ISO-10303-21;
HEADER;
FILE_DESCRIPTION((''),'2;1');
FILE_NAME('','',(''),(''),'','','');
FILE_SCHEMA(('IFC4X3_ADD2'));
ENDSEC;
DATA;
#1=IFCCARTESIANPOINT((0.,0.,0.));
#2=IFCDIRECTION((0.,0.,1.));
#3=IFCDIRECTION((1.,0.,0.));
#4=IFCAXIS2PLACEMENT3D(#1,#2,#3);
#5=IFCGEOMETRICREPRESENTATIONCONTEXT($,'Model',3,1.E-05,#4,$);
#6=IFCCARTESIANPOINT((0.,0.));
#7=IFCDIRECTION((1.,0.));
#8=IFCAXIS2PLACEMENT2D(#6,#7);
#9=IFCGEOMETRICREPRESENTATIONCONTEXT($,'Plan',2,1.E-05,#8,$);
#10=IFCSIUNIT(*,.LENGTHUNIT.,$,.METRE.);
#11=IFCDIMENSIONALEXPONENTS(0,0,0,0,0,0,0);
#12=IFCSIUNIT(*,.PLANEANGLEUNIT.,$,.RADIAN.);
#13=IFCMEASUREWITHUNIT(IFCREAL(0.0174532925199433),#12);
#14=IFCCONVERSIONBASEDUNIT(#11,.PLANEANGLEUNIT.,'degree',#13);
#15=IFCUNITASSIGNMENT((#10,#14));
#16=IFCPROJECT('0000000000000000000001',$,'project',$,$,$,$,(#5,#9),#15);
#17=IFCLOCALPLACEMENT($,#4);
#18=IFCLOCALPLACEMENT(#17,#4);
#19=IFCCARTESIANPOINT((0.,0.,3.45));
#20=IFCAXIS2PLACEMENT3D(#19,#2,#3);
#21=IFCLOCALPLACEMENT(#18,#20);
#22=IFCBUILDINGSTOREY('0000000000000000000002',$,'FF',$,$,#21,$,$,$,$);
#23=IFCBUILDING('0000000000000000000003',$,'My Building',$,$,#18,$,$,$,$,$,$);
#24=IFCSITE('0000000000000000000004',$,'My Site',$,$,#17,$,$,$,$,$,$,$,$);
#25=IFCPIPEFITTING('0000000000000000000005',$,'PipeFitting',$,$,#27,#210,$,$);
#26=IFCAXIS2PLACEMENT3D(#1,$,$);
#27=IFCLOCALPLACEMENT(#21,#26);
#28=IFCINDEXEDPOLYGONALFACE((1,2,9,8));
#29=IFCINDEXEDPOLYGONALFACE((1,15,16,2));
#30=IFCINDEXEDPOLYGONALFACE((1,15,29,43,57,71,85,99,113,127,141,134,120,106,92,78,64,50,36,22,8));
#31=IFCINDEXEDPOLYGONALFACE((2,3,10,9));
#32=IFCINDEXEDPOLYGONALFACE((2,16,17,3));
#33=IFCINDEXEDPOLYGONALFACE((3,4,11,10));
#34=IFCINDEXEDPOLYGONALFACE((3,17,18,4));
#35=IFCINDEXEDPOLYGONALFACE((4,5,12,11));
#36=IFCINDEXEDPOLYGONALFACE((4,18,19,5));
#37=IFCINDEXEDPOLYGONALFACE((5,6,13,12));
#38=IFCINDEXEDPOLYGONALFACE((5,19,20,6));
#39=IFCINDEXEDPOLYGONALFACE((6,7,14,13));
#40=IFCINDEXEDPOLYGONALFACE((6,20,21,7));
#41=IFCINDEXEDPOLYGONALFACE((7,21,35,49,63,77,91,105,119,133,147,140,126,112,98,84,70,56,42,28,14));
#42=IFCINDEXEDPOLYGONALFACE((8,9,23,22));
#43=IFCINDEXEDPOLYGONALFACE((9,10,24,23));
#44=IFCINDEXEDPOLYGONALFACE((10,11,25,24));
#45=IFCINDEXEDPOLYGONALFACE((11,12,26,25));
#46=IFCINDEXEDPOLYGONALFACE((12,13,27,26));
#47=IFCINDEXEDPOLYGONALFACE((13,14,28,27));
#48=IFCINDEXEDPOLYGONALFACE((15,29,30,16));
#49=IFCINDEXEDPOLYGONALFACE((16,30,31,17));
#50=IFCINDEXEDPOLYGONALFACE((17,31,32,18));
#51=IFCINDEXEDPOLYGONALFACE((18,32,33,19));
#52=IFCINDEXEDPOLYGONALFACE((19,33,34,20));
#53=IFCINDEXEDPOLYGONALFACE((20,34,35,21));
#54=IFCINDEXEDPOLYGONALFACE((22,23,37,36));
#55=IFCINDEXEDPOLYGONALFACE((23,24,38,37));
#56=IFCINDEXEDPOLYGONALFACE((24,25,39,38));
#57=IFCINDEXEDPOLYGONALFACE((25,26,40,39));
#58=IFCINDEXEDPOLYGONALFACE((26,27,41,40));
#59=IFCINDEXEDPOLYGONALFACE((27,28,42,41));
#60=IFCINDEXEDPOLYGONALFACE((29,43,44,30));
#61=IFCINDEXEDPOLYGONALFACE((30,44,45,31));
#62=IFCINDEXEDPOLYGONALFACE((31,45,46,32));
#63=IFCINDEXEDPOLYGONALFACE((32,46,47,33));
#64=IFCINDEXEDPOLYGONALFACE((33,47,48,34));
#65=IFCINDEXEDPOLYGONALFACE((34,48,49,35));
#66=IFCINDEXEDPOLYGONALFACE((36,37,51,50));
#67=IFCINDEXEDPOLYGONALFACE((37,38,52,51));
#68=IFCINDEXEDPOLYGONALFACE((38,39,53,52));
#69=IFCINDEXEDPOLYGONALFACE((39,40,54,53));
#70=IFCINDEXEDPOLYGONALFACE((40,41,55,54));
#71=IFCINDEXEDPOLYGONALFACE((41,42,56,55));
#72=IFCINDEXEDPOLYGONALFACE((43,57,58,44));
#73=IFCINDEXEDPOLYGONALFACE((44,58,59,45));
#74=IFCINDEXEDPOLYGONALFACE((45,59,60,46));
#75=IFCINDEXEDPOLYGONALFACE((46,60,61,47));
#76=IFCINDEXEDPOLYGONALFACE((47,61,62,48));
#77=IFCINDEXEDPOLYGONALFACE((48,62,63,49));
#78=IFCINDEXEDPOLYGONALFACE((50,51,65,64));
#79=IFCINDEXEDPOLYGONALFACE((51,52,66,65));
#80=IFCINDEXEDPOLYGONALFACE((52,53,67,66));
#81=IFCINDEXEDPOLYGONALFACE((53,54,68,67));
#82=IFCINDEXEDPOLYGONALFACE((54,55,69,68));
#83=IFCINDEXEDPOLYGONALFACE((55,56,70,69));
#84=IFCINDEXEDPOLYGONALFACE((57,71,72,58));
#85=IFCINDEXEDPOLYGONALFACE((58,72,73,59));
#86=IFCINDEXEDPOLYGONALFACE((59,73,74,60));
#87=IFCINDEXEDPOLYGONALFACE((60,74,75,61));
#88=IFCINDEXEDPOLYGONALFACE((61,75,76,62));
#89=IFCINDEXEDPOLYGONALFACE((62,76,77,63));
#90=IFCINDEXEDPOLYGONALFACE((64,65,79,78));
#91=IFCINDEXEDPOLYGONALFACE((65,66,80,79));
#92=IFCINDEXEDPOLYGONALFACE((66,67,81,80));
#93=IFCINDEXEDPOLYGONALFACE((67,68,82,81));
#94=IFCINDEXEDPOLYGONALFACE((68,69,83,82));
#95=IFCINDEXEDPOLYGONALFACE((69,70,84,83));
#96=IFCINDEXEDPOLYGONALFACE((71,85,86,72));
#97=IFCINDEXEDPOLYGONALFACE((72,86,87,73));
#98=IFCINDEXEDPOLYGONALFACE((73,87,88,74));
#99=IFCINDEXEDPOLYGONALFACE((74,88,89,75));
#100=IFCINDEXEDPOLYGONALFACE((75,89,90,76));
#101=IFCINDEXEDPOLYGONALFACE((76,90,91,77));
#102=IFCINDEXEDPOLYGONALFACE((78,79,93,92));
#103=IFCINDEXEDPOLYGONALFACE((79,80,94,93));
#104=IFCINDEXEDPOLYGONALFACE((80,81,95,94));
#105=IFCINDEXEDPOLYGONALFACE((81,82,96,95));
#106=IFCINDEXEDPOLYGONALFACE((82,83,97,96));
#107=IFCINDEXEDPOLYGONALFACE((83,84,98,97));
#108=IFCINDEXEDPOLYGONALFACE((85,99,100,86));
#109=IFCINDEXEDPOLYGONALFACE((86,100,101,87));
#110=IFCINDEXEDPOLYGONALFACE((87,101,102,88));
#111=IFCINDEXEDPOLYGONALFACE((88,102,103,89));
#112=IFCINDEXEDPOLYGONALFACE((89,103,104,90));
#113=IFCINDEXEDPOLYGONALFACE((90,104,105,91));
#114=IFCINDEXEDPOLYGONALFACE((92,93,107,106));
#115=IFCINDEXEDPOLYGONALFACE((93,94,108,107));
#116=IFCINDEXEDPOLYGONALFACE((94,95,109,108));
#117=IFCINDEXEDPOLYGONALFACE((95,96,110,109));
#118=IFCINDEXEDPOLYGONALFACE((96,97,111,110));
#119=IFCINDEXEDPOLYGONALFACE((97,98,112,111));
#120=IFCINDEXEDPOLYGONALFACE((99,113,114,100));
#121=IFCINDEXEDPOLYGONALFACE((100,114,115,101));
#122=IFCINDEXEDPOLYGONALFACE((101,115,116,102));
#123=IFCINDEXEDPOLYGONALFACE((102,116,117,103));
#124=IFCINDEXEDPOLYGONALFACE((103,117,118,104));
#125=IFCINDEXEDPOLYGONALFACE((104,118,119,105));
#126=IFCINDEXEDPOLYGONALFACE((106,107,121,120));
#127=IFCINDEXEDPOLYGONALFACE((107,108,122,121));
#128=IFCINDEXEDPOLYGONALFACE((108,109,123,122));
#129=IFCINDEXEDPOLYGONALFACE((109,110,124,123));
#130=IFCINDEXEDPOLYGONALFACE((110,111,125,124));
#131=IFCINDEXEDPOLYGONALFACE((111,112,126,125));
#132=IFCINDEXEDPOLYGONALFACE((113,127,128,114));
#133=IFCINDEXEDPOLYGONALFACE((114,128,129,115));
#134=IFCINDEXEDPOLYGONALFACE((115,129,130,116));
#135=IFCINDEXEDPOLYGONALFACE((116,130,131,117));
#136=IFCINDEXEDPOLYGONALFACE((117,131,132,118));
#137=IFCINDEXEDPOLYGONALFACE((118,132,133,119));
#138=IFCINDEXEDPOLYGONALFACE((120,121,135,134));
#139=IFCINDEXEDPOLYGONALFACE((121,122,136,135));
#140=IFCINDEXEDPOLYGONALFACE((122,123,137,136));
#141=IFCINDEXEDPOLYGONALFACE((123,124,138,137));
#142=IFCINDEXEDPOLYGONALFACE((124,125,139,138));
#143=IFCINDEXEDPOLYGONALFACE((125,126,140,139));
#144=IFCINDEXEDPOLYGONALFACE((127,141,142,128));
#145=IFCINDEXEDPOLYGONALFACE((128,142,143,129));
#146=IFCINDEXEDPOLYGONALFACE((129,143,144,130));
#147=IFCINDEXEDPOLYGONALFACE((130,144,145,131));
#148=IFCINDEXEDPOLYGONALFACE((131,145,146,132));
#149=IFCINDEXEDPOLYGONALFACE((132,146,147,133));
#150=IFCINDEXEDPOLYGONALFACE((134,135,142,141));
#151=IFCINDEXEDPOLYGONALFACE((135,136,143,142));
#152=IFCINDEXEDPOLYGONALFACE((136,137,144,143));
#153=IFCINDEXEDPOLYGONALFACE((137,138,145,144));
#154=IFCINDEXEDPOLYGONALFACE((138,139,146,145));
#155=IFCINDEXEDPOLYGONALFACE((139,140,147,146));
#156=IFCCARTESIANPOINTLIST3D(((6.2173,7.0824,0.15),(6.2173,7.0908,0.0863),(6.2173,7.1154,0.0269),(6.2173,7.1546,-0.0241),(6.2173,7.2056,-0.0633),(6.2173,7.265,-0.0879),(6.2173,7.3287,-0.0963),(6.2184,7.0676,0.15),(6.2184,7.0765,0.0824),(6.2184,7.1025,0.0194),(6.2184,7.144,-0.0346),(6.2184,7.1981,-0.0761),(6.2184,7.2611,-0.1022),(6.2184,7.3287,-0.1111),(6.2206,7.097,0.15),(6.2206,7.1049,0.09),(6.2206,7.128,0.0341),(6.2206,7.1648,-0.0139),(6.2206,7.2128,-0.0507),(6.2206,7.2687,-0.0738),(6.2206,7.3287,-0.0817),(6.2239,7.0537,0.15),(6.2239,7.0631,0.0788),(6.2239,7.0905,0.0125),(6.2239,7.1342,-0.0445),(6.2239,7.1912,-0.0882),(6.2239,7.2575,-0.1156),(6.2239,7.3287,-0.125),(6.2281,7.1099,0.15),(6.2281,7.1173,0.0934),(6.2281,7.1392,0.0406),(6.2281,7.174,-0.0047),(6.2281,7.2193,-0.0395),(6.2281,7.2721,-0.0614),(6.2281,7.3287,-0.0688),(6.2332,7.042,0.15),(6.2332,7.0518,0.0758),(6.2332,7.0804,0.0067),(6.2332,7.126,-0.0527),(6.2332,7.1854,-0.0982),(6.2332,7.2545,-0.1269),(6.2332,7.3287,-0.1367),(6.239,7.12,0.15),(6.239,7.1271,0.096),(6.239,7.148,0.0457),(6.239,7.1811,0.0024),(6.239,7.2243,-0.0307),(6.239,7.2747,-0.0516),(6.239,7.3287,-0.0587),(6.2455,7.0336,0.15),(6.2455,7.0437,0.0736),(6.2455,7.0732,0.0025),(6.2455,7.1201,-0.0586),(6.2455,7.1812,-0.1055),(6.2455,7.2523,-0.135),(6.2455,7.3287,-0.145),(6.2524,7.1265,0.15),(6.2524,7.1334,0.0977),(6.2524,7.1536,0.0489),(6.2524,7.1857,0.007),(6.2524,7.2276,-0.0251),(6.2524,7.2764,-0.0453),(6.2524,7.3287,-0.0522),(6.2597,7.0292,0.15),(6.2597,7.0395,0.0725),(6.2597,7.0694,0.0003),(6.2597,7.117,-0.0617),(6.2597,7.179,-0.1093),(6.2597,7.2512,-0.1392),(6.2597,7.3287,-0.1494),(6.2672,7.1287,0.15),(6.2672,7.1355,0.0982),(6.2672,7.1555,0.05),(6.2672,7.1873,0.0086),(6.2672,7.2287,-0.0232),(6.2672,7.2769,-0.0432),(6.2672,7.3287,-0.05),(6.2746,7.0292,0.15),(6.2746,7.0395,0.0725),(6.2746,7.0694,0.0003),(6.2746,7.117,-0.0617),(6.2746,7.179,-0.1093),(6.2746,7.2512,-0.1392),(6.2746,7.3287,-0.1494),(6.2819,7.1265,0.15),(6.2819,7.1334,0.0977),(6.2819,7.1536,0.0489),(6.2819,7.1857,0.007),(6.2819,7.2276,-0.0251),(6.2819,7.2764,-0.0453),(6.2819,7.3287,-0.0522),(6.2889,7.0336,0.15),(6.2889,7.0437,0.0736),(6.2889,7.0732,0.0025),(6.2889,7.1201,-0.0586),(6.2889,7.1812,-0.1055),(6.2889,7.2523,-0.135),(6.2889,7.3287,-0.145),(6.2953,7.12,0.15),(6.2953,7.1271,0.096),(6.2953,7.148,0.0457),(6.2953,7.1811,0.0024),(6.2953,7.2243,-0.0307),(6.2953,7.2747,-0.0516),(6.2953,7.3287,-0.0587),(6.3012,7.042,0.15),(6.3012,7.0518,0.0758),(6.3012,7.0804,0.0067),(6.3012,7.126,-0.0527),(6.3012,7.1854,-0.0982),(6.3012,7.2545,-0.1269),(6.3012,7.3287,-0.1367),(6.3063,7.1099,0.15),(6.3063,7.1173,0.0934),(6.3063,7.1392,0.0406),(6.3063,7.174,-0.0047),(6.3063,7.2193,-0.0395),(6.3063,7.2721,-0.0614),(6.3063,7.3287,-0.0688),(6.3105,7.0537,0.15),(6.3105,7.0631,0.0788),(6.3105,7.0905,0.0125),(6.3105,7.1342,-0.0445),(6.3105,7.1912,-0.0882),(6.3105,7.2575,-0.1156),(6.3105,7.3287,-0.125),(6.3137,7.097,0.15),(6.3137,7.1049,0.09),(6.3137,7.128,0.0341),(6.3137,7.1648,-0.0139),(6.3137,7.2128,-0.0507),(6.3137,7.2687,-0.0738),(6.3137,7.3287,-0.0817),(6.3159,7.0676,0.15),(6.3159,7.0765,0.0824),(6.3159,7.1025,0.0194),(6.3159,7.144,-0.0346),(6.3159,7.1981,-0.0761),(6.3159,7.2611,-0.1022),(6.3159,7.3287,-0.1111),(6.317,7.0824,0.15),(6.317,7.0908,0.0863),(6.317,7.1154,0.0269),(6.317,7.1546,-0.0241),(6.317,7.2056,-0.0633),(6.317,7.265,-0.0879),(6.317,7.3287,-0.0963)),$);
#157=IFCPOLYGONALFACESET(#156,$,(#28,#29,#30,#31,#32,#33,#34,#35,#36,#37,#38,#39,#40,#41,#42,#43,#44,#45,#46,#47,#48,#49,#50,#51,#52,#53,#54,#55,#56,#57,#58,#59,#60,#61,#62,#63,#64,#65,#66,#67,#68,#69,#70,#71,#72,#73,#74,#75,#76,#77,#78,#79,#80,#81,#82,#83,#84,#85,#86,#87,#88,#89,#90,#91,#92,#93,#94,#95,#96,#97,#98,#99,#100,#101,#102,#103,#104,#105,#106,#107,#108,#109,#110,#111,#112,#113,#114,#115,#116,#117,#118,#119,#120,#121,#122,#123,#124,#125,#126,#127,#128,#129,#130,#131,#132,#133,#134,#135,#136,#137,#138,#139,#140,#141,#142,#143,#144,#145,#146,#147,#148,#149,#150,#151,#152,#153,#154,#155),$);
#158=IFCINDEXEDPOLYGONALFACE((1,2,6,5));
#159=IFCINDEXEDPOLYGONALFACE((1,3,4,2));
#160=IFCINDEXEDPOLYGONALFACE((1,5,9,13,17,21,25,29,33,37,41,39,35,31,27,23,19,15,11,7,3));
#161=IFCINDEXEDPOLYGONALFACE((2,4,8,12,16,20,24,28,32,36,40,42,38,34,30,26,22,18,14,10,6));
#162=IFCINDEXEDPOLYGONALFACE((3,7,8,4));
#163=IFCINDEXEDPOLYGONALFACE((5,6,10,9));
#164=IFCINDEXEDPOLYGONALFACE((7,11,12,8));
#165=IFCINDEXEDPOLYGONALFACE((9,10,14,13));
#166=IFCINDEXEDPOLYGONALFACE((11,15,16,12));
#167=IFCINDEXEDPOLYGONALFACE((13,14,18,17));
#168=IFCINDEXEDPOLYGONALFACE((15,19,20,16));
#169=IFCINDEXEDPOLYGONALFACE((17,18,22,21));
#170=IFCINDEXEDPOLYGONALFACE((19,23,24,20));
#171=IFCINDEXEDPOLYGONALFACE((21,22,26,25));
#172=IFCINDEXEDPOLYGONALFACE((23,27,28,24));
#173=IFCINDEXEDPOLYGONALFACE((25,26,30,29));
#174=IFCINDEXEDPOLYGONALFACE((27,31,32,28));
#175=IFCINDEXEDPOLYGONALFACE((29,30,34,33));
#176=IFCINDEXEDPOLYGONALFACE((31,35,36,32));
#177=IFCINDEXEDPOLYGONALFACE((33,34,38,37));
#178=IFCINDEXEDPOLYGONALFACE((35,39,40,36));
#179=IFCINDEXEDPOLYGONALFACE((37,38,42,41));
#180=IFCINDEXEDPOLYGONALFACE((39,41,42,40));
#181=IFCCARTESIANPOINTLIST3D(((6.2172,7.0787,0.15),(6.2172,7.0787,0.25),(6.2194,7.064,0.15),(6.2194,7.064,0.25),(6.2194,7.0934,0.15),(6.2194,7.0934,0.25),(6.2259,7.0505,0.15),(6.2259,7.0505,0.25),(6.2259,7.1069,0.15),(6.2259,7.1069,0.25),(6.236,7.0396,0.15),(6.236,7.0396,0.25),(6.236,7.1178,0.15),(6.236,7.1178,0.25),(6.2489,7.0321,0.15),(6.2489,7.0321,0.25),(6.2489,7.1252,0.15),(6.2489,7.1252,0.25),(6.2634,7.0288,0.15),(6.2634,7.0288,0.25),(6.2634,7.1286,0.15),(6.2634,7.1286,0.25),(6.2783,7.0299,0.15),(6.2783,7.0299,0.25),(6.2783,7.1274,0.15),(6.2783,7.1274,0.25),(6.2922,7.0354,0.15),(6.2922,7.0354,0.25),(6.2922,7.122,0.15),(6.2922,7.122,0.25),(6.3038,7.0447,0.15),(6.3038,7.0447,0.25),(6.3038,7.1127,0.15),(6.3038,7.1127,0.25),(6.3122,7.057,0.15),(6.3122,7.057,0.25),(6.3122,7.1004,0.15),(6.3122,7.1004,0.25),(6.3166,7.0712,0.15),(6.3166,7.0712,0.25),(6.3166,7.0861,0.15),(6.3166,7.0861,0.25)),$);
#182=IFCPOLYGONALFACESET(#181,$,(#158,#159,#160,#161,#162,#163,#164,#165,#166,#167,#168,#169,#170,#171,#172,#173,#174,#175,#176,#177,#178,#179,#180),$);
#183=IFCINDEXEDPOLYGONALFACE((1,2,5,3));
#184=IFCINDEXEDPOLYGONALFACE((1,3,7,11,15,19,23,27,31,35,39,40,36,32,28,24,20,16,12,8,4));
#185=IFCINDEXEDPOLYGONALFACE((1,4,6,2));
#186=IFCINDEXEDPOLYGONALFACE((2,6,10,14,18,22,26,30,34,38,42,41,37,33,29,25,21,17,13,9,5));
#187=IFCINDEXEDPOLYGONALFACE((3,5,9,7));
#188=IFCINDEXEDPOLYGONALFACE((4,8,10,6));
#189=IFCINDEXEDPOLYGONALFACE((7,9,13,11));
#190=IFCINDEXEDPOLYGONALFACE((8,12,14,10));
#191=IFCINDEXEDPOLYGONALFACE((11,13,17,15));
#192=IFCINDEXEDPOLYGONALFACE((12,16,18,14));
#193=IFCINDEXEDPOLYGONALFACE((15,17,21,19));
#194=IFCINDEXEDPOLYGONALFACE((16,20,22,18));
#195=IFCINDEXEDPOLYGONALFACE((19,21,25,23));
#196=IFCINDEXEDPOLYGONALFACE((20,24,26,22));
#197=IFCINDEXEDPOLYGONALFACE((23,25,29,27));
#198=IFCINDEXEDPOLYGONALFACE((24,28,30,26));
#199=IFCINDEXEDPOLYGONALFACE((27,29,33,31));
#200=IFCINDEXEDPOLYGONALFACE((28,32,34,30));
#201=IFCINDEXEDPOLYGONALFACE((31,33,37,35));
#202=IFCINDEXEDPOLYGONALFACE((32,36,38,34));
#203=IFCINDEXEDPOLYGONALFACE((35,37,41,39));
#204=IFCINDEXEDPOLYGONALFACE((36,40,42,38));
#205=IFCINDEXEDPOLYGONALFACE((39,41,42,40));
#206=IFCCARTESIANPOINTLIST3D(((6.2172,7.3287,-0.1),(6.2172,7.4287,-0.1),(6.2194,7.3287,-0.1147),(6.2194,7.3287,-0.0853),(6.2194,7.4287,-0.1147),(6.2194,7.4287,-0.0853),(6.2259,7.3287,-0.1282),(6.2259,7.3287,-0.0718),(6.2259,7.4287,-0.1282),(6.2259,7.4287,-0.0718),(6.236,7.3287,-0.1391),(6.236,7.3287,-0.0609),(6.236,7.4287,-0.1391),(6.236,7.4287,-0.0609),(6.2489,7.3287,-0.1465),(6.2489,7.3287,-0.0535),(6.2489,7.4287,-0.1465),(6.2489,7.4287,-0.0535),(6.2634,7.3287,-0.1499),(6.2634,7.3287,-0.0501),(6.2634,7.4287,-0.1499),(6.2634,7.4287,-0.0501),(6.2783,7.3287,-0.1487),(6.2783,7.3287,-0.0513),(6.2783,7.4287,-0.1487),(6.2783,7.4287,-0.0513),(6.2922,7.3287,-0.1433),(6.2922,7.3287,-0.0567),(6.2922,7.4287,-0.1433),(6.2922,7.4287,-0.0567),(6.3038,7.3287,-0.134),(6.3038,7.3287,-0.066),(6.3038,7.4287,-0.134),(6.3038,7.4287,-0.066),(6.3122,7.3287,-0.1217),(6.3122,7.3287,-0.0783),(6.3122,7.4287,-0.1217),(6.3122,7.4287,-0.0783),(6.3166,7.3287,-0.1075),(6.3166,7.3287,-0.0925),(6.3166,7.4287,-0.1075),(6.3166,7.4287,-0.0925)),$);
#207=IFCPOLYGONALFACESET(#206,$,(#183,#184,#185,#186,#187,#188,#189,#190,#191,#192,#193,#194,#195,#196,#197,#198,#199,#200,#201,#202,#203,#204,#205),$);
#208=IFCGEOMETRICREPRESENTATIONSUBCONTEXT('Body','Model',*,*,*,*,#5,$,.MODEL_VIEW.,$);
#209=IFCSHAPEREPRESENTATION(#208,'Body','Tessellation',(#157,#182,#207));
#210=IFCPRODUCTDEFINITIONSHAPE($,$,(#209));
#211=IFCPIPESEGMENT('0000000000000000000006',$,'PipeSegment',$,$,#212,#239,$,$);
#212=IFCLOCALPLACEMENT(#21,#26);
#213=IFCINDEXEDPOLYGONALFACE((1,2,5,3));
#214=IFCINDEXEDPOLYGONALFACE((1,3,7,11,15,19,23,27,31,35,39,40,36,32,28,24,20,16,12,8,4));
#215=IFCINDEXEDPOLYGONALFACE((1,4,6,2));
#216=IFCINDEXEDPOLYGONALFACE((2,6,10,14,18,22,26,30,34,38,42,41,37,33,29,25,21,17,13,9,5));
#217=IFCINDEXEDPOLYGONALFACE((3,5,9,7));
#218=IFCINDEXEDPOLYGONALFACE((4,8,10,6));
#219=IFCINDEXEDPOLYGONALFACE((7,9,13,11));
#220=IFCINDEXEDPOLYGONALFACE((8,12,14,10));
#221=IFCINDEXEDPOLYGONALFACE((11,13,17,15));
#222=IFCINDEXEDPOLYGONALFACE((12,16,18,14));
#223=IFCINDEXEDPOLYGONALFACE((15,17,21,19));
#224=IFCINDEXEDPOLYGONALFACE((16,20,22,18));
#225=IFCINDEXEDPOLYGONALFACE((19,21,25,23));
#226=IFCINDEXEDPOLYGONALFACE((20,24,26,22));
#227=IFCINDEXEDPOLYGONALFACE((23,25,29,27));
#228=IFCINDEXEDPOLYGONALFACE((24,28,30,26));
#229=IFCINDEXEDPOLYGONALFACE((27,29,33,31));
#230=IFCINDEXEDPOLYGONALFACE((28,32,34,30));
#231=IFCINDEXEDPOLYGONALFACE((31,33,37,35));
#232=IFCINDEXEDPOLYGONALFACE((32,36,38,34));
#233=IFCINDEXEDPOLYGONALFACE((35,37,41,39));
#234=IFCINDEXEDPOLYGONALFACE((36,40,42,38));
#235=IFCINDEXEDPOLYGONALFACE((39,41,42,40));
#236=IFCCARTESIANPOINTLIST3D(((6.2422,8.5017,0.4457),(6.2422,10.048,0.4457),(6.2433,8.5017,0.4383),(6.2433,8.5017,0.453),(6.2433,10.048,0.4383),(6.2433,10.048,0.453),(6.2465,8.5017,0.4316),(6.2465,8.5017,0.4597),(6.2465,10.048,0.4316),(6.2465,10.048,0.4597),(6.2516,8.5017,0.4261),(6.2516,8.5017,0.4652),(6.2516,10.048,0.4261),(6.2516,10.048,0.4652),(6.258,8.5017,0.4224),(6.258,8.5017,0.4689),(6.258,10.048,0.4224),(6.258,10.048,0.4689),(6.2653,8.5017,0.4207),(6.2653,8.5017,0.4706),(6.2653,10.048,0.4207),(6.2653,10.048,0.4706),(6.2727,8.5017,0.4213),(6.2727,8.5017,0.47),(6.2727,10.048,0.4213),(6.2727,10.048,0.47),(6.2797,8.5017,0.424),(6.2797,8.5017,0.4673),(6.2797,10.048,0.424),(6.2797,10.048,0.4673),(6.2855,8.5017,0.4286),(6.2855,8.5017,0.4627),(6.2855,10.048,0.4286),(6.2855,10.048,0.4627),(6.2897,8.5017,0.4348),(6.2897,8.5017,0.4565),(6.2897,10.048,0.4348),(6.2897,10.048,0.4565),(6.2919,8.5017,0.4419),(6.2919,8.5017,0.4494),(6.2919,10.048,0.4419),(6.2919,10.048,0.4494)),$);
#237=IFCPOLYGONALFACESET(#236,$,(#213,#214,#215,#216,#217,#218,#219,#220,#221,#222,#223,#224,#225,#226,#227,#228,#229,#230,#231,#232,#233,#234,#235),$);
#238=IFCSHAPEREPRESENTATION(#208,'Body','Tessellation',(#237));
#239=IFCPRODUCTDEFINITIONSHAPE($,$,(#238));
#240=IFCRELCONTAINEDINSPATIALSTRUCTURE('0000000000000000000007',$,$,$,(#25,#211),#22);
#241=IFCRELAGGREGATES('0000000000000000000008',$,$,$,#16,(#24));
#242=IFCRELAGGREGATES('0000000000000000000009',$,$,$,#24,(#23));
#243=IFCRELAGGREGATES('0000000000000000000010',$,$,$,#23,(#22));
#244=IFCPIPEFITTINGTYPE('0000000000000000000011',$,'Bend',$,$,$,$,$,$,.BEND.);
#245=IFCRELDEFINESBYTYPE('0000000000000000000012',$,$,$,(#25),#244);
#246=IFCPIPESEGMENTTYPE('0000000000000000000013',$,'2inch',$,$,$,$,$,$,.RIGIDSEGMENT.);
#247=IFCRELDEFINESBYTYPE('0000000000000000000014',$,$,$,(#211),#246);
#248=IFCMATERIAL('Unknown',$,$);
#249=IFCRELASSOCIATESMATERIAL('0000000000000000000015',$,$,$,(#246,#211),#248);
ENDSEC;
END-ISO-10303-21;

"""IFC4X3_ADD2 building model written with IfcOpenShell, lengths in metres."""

from ifc_helpers import new_model, entity, si_unit, converted_unit, frame, origin_with_axes, origin_2d_with_axis, place, context, subcontext, project, spatial, circle, extrude, source, transform, mapped, material, material_profile, profile_set, profile_usage, type_object, type_shapes, element, save


model = new_model("IFC4X3_ADD2")

# Units and contexts
model_context = context("Model", 3, precision=1e-05, world=origin_with_axes())
plan_context = context("Plan", 2, precision=1e-05, world=origin_2d_with_axis())
body_context = subcontext(model_context, "Body", "Model", "MODEL_VIEW")
ifc_project = project(units=[si_unit("LENGTHUNIT", "METRE"), converted_unit("PLANEANGLEUNIT", "degree", entity("IfcReal", 0.0174532925199433), si_unit("PLANEANGLEUNIT", "RADIAN"), dimensions=[0, 0, 0, 0, 0, 0, 0])], contexts=[model_context, plan_context])

# Site, building, storey
site_placement = place(None, origin_with_axes())
site = spatial("IfcSite", under=ifc_project, at=site_placement, Name="My Site")
building_placement = place(site_placement, origin_with_axes())
building = spatial("IfcBuilding", under=site, at=building_placement, Name="My Building")
storey_placement = place(building_placement, frame((0.0, 0.0, 3.45), z_axis=(0.0, 0.0, 1.0), x_axis=(1.0, 0.0, 0.0)))
storey = spatial("IfcBuildingStorey", under=building, at=storey_placement, Name="FF")

# Shared definitions
ifc_material_1 = material(Name="Unknown")

# Pipe fitting
pipe_fitting_type_1 = type_object("IfcPipeFittingType", Name="Bend", PredefinedType="BEND")
shared_shape_1 = source(origin_with_axes(), body_context, "Body", "SolidModel", [
    entity("IfcSweptDiskSolid", entity("IfcIndexedPolyCurve", entity("IfcCartesianPointList3D", [[0.0, 0.0, -0.1], [0.0, -0.0732, -0.2768], [0.0, -0.25, -0.35]]), [entity("IfcArcIndex", [1, 2, 3])]), 0.05),
    extrude(circle(Radius=0.05), origin_with_axes(), (0.0, 0.0, -1.0), 0.1),
    extrude(circle(Radius=0.05), frame((0.0, -0.25, -0.35), z_axis=(0.0, -1.0, 0.0), x_axis=(1.0, 0.0, 0.0)), (0.0, 0.0, 1.0), 0.1),
])
type_shapes(pipe_fitting_type_1, [shared_shape_1])
pipe_fitting_1_placement = place(storey_placement, frame((6.2672, 7.0787, 0.25), z_axis=(0.0, 0.0, 1.0), x_axis=(-1.0, 0.0, 0.0)))
element("IfcPipeFitting", 1, at=pipe_fitting_1_placement, inside=storey, type_object=pipe_fitting_type_1, Name="PipeFitting", context=body_context, shape_type="MappedRepresentation", body=[
    mapped(shared_shape_1, transform((0.0, 0.0, 0.0), x_axis=(1.0, 0.0, 0.0), y_axis=(0.0, 1.0, 0.0), z_axis=(0.0, 0.0, 1.0), scale=1.0)),
])

# Pipe segment
ifc_material_profile_1 = material_profile(ifc_material_1, circle(Radius=0.025))
ifc_profile_set_1 = profile_set([ifc_material_profile_1])
ifc_profile_usage_1 = profile_usage(ifc_profile_set_1)
pipe_segment_type_1 = type_object("IfcPipeSegmentType", Name="2inch", PredefinedType="RIGIDSEGMENT", material=ifc_profile_set_1)
pipe_segment_1_placement = place(storey_placement, frame((6.2672, 8.5017, 0.4457), z_axis=(0.0, 1.0, 0.0), x_axis=(-1.0, 0.0, 0.0)))
element("IfcPipeSegment", 2, at=pipe_segment_1_placement, inside=storey, type_object=pipe_segment_type_1, material=ifc_profile_usage_1, Name="PipeSegment", context=body_context, shape_type="SweptSolid", body=[
    extrude(circle(Radius=0.025), origin_with_axes(), (0.0, 0.0, 1.0), 1.5464),
])

save(model, "model.ifc")
